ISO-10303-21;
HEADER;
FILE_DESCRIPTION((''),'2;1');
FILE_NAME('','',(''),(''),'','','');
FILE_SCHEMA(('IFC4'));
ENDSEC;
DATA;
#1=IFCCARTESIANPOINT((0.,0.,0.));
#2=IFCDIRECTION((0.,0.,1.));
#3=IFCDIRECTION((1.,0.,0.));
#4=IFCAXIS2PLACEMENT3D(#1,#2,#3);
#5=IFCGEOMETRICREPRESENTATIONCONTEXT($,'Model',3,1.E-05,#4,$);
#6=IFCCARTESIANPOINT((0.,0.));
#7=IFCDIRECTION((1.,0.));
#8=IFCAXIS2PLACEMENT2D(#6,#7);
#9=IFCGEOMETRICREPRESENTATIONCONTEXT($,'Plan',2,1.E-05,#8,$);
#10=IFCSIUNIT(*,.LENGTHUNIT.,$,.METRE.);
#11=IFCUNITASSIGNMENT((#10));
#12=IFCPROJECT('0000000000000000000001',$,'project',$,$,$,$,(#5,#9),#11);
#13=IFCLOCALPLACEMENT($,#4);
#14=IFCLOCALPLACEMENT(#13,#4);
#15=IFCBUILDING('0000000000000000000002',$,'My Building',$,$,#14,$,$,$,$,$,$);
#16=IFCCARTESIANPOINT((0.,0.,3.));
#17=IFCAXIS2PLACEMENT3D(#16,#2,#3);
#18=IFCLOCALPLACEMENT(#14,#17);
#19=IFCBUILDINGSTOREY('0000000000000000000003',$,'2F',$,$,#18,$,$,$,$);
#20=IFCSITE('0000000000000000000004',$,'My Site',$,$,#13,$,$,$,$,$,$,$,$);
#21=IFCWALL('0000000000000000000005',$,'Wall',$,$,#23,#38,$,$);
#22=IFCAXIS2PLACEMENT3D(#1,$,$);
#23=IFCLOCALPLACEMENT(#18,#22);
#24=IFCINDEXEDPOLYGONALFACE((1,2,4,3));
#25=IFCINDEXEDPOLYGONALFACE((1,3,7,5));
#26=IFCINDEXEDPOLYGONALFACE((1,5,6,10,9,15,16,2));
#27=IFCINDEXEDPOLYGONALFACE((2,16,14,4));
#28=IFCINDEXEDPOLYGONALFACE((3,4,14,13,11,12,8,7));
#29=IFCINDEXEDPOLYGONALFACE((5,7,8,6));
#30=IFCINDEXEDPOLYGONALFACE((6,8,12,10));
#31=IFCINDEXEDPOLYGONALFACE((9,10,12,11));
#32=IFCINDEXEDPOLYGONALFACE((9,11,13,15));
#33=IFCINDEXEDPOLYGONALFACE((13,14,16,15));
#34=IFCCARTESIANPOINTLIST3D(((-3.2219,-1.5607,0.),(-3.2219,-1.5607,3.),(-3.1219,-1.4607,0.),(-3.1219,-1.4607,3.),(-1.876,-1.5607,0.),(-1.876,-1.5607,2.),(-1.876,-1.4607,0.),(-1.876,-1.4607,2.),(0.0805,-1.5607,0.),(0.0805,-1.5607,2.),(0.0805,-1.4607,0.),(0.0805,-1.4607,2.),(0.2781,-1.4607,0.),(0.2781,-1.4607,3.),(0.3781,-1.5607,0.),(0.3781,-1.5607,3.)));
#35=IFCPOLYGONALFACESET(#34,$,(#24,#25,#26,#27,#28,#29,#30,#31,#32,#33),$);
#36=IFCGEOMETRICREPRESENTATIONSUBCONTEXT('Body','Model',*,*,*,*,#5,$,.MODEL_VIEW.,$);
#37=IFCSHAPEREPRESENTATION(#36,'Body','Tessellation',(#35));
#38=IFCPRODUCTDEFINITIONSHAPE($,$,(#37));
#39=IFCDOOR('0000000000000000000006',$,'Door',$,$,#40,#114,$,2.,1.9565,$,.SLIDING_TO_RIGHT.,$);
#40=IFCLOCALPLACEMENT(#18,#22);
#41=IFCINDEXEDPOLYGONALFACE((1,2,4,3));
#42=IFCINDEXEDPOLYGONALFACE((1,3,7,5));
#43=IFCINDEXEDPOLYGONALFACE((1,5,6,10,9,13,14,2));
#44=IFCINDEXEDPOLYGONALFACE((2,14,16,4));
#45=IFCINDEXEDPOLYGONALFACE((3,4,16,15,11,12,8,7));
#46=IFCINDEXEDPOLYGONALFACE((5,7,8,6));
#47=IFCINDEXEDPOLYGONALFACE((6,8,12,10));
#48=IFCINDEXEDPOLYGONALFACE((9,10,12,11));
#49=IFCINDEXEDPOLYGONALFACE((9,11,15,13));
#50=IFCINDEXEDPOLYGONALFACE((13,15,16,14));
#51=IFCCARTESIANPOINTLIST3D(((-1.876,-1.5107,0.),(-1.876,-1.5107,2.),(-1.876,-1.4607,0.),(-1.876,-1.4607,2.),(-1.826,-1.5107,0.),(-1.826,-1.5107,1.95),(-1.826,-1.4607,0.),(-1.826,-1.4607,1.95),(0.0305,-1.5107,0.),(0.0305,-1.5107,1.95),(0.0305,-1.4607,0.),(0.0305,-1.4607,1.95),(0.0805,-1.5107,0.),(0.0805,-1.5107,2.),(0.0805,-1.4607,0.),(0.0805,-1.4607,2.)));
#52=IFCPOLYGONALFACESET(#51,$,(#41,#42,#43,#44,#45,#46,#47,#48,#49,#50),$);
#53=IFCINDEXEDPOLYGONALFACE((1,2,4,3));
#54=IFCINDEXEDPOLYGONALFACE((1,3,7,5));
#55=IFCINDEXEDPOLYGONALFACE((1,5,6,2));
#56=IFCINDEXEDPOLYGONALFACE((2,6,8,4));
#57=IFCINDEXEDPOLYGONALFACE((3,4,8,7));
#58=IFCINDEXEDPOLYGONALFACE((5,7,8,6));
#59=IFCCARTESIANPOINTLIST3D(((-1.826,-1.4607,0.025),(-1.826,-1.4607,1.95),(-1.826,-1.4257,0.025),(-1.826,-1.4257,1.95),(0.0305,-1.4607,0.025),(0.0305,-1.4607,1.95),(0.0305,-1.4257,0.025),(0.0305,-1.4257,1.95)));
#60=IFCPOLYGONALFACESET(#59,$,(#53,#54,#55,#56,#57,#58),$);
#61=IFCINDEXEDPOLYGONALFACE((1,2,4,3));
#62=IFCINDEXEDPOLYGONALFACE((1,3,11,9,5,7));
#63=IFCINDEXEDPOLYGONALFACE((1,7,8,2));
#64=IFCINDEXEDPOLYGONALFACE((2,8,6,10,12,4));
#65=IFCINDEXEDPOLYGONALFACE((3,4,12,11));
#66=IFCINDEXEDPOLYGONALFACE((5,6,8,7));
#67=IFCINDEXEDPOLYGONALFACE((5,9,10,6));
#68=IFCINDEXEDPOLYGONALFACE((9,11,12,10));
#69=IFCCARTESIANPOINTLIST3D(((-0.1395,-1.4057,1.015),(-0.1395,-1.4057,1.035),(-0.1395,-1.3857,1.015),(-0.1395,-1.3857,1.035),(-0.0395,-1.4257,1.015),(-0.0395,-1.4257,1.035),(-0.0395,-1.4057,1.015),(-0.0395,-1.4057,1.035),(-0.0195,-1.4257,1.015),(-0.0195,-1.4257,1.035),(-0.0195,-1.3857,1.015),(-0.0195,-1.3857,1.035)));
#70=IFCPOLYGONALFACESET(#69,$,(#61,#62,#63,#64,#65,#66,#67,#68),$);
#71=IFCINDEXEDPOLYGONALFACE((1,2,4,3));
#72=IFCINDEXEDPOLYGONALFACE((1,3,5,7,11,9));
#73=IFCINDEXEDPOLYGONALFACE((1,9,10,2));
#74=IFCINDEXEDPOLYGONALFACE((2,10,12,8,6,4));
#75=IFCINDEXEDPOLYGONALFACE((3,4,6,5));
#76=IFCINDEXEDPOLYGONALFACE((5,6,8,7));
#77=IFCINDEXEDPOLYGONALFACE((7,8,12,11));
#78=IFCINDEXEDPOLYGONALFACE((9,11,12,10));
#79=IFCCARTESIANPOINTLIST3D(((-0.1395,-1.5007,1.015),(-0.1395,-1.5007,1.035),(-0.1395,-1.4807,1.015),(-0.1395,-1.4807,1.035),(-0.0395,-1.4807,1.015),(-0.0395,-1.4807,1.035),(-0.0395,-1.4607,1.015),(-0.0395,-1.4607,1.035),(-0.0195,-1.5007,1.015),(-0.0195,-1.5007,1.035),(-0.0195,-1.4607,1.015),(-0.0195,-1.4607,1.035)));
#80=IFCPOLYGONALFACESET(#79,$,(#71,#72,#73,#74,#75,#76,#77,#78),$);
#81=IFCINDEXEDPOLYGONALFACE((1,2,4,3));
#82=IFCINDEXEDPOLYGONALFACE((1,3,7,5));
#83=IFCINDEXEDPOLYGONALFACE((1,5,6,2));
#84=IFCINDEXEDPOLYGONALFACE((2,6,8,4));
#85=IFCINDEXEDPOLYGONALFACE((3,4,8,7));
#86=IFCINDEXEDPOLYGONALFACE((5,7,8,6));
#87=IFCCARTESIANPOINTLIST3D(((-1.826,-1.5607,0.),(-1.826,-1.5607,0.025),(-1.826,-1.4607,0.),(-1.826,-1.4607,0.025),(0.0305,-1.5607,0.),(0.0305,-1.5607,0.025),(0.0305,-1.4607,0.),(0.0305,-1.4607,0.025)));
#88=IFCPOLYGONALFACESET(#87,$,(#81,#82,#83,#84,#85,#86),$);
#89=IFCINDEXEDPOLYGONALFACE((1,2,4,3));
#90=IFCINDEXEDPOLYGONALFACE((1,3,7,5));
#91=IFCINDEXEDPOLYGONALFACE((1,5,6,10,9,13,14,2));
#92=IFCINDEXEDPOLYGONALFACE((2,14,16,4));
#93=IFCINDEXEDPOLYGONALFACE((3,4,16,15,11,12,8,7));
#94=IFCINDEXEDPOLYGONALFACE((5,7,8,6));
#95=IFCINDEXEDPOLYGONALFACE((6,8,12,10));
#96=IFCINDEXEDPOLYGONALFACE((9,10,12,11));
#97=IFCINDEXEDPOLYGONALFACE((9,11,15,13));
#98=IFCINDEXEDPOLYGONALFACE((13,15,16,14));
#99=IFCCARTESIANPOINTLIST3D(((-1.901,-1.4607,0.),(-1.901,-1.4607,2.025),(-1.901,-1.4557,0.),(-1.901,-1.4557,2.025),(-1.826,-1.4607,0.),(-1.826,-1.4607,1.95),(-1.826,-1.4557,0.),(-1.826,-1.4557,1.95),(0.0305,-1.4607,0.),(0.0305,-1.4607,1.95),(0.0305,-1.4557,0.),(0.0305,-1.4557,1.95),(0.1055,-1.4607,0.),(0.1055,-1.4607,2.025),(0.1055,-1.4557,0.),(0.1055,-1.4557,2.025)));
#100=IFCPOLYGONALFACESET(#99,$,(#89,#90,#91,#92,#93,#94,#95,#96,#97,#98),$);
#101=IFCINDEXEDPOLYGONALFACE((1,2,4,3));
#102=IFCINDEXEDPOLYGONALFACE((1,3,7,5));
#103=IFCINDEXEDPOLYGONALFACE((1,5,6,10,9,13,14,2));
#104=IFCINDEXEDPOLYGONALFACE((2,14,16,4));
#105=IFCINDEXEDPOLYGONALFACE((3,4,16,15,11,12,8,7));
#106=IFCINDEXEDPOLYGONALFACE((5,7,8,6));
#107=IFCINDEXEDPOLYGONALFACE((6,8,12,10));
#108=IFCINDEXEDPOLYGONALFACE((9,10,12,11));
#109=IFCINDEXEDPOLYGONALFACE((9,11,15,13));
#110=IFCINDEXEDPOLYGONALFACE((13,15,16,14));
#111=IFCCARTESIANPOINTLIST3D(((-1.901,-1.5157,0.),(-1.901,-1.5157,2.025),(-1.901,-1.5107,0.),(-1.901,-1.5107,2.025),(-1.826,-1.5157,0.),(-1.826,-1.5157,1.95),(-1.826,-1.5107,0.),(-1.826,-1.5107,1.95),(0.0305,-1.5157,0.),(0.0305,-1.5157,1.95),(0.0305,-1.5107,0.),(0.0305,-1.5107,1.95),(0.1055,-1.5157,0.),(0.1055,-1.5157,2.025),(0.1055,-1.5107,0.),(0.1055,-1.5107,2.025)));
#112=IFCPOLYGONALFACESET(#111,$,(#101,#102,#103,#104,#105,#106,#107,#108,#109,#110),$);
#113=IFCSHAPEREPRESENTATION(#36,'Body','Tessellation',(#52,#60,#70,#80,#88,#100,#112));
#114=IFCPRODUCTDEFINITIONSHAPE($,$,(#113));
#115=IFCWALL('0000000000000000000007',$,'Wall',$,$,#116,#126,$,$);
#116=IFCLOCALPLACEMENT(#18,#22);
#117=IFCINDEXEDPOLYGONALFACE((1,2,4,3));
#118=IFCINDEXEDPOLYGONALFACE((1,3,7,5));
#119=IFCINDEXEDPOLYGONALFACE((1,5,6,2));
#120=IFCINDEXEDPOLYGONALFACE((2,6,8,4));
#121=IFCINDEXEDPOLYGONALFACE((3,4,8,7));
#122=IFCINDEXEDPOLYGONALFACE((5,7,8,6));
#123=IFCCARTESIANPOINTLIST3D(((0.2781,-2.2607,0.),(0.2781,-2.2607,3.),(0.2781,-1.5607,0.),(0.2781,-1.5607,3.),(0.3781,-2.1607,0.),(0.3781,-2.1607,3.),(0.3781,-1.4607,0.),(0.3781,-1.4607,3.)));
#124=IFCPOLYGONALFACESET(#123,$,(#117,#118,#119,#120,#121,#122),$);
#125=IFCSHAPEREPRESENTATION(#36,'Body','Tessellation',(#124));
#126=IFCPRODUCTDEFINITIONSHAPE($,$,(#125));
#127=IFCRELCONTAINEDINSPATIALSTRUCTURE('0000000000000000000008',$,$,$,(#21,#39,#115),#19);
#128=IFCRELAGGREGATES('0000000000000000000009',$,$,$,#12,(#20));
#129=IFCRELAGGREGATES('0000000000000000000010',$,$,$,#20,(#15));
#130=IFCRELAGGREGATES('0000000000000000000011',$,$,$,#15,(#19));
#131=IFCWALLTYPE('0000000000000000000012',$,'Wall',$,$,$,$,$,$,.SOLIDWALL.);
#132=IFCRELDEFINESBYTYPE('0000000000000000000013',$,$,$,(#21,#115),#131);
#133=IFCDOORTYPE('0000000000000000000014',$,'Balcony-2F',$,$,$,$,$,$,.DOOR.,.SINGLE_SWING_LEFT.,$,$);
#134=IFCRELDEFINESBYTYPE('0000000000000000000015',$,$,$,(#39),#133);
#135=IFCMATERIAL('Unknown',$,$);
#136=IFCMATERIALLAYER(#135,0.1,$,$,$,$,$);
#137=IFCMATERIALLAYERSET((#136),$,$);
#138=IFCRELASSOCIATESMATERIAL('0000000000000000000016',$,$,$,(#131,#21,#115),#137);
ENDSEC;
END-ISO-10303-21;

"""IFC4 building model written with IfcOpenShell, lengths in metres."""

from ifc_helpers import new_model, entity, si_unit, frame, origin_with_axes, origin_2d_with_axis, place, context, subcontext, project, spatial, line, indexed_curve, outline, extrude, shape, source, transform, mapped, material, layer, layer_set, layer_usage, type_object, type_shapes, element, fill, save


model = new_model("IFC4")

# Units and contexts
model_context = context("Model", 3, precision=1e-05, world=origin_with_axes())
plan_context = context("Plan", 2, precision=1e-05, world=origin_2d_with_axis())
body_context_1 = subcontext(model_context, "Body", "Model", "MODEL_VIEW")
body_context_2 = subcontext(plan_context, "Body", "Plan", "PLAN_VIEW")
ifc_project = project(units=[si_unit("LENGTHUNIT", "METRE")], contexts=[model_context, plan_context])

# Site, building, storey
site_placement = place(None, origin_with_axes())
site = spatial("IfcSite", under=ifc_project, at=site_placement, Name="My Site")
building_placement = place(site_placement, origin_with_axes())
building = spatial("IfcBuilding", under=site, at=building_placement, Name="My Building")
storey_placement = place(building_placement, frame((0.0, 0.0, 3.0), z_axis=(0.0, 0.0, 1.0), x_axis=(1.0, 0.0, 0.0)))
storey = spatial("IfcBuildingStorey", under=building, at=storey_placement, Name="2F")

# Shared definitions
ifc_material = material(Name="Unknown")

# Shared definitions
ifc_layer_1 = layer(ifc_material, 0.1)
ifc_layer_set_1 = layer_set([ifc_layer_1])
wall_type = type_object("IfcWallType", Name="Wall", PredefinedType="SOLIDWALL", material=ifc_layer_set_1)

# Wall, opening, door
ifc_layer_usage_1 = layer_usage(ifc_layer_set_1, "AXIS2", "POSITIVE", 0.0)
wall_1_placement = place(storey_placement, frame((-3.2219, -1.5607, 0.0), z_axis=(0.0, 0.0, 1.0), x_axis=(1.0, 0.0, 0.0)))
wall_1 = element("IfcWall", 1, at=wall_1_placement, inside=storey, type_object=wall_type, material=ifc_layer_usage_1, Name="Wall", context=body_context_1, shape_type="SweptSolid", body=[
    extrude(outline(indexed_curve([(0.0, 0.0), (0.1, 0.1), (3.5, 0.1), (3.6, 0.0)], segments=[line(1, 2, 3, 4, 1)])), origin_with_axes(), (0.0, 0.0, 1.0), 3.0),
])
shared_shape_1 = source(origin_with_axes(), body_context_1, "Body", "SweptSolid", [
    extrude(outline(indexed_curve([(0.0, 0.0), (1.9565, 0.0), (1.9565, 2.0), (0.0, 2.0)], segments=[line(1, 2, 3, 4, 1)])), frame((0.0, -0.6, 0.0), z_axis=(0.0, -1.0, 0.0), x_axis=(1.0, 0.0, 0.0)), (0.0, 0.0, -1.0), 1.2),
])
opening_1_placement = place(wall_1_placement, frame((3.3023, 0.1, 0.0), z_axis=(0.0, 0.0, 1.0), x_axis=(-1.0, 0.0, 0.0)))
opening_1 = element("IfcOpeningElement", 2, at=opening_1_placement, cuts=wall_1, PredefinedType="OPENING", context=body_context_1, shape_type="MappedRepresentation", body=[
    mapped(shared_shape_1, transform((0.0, 0.0, 0.0), x_axis=(1.0, 0.0, 0.0), y_axis=(0.0, 1.0, 0.0), z_axis=(0.0, 0.0, 1.0), scale=1.0)),
])
door_type_1 = type_object("IfcDoorType", Name="Balcony-2F", OperationType="SINGLE_SWING_LEFT", PredefinedType="DOOR")
shared_shape_2 = source(origin_with_axes(), body_context_1, "Body", "SweptSolid", [
    extrude(outline(indexed_curve([(0.0, 0.0), (0.0, 2.0), (1.9565, 2.0), (1.9565, 0.0), (1.9065, 0.0), (1.9065, 1.95), (0.05, 1.95), (0.05, 0.0)], segments=[line(1, 2, 3, 4, 5, 6, 7, 8, 1)])), frame((0.0, 0.0, 0.0), z_axis=(0.0, -1.0, 0.0), x_axis=(1.0, 0.0, 0.0)), (0.0, 0.0, -1.0), 0.05),
    extrude(outline(indexed_curve([(0.0, 0.0), (1.8565, 0.0), (1.8565, 0.035), (0.0, 0.035)], segments=[line(1, 2, 3, 4, 1)])), frame((0.05, -0.035, 0.025), z_axis=(0.0, 0.0, 1.0), x_axis=(1.0, 0.0, 0.0)), (0.0, 0.0, 1.0), 1.925),
    extrude(outline(indexed_curve([(0.0, 0.0), (0.0, -0.04), (0.12, -0.04), (0.12, -0.02), (0.02, -0.02), (0.02, 0.0)], segments=[line(1, 2, 3, 4, 5, 6, 1)])), frame((0.1, -0.035, 1.015), z_axis=(0.0, 0.0, 1.0), x_axis=(1.0, 0.0, 0.0)), (0.0, 0.0, 1.0), 0.02),
    extrude(outline(indexed_curve([(0.0, 0.0), (0.0, 0.04), (0.12, 0.04), (0.12, 0.02), (0.02, 0.02), (0.02, 0.0)], segments=[line(1, 2, 3, 4, 5, 6, 1)])), frame((0.1, 0.0, 1.015), z_axis=(0.0, 0.0, 1.0), x_axis=(1.0, 0.0, 0.0)), (0.0, 0.0, 1.0), 0.02),
    extrude(outline(indexed_curve([(0.0, 0.0), (1.8565, 0.0), (1.8565, 0.1), (0.0, 0.1)], segments=[line(1, 2, 3, 4, 1)])), frame((0.05, 0.0, 0.0), z_axis=(0.0, 0.0, 1.0), x_axis=(1.0, 0.0, 0.0)), (0.0, 0.0, 1.0), 0.025),
    extrude(outline(indexed_curve([(0.0, 0.0), (0.0, 2.025), (2.0065, 2.025), (2.0065, 0.0), (1.9315, 0.0), (1.9315, 1.95), (0.075, 1.95), (0.075, 0.0)], segments=[line(1, 2, 3, 4, 5, 6, 7, 8, 1)])), frame((-0.025, -0.005, 0.0), z_axis=(0.0, -1.0, 0.0), x_axis=(1.0, 0.0, 0.0)), (0.0, 0.0, -1.0), 0.005),
    extrude(outline(indexed_curve([(0.0, 0.0), (0.0, 2.025), (2.0065, 2.025), (2.0065, 0.0), (1.9315, 0.0), (1.9315, 1.95), (0.075, 1.95), (0.075, 0.0)], segments=[line(1, 2, 3, 4, 5, 6, 7, 8, 1)])), frame((-0.025, 0.05, 0.0), z_axis=(0.0, -1.0, 0.0), x_axis=(1.0, 0.0, 0.0)), (0.0, 0.0, -1.0), 0.005),
])
shared_shape_3 = source(origin_with_axes(), body_context_2, "Body", "Curve2D", [
    entity("IfcIndexedPolyCurve", entity("IfcCartesianPointList2D", [[0.0, 0.0], [0.05, 0.0], [0.05, 0.05], [0.0, 0.05]]), [entity("IfcLineIndex", [1, 2, 3, 4, 1])]),
    entity("IfcIndexedPolyCurve", entity("IfcCartesianPointList2D", [[1.9565, 0.0], [1.9065, 0.0], [1.9065, 0.05], [1.9565, 0.05]]), [entity("IfcLineIndex", [1, 2, 3, 4, 1])]),
    entity("IfcIndexedPolyCurve", entity("IfcCartesianPointList2D", [[2.8347, -0.035], [0.9782, -0.035], [0.9782, 0.0], [2.8347, 0.0]]), [entity("IfcLineIndex", [1, 2, 3, 4, 1])]),
])
type_shapes(door_type_1, [shared_shape_2, shared_shape_3])
door_1_placement = place(opening_1_placement, origin_with_axes())
door_1 = element("IfcDoor", 3, at=door_1_placement, inside=storey, type_object=door_type_1, Name="Door", OperationType="SLIDING_TO_RIGHT", OverallHeight=2.0, OverallWidth=1.9565, shapes=[
    shape(body_context_1, "Body", "MappedRepresentation", [mapped(shared_shape_2, transform((0.0, 0.0, 0.0), x_axis=(1.0, 0.0, 0.0), y_axis=(0.0, 1.0, 0.0), z_axis=(0.0, 0.0, 1.0), scale=1.0))]),
    shape(body_context_2, "Body", "MappedRepresentation", [mapped(shared_shape_3, transform((0.0, 0.0, 0.0), x_axis=(1.0, 0.0, 0.0), y_axis=(0.0, 1.0, 0.0), z_axis=(0.0, 0.0, 1.0), scale=1.0))]),
])
fill(opening_1, door_1)

# Wall
ifc_layer_usage_2 = layer_usage(ifc_layer_set_1, "AXIS2", "POSITIVE", 0.0)
wall_2_placement = place(storey_placement, frame((0.2781, -1.5607, 0.0), z_axis=(0.0, 0.0, 1.0), x_axis=(0.0, -1.0, 0.0)))
element("IfcWall", 4, at=wall_2_placement, inside=storey, type_object=wall_type, material=ifc_layer_usage_2, Name="Wall", context=body_context_1, shape_type="SweptSolid", body=[
    extrude(outline(indexed_curve([(0.0, 0.0), (-0.1, 0.1), (0.6, 0.1), (0.7, 0.0)], segments=[line(1, 2, 3, 4, 1)])), origin_with_axes(), (0.0, 0.0, 1.0), 3.0),
])

save(model, "model.ifc")
